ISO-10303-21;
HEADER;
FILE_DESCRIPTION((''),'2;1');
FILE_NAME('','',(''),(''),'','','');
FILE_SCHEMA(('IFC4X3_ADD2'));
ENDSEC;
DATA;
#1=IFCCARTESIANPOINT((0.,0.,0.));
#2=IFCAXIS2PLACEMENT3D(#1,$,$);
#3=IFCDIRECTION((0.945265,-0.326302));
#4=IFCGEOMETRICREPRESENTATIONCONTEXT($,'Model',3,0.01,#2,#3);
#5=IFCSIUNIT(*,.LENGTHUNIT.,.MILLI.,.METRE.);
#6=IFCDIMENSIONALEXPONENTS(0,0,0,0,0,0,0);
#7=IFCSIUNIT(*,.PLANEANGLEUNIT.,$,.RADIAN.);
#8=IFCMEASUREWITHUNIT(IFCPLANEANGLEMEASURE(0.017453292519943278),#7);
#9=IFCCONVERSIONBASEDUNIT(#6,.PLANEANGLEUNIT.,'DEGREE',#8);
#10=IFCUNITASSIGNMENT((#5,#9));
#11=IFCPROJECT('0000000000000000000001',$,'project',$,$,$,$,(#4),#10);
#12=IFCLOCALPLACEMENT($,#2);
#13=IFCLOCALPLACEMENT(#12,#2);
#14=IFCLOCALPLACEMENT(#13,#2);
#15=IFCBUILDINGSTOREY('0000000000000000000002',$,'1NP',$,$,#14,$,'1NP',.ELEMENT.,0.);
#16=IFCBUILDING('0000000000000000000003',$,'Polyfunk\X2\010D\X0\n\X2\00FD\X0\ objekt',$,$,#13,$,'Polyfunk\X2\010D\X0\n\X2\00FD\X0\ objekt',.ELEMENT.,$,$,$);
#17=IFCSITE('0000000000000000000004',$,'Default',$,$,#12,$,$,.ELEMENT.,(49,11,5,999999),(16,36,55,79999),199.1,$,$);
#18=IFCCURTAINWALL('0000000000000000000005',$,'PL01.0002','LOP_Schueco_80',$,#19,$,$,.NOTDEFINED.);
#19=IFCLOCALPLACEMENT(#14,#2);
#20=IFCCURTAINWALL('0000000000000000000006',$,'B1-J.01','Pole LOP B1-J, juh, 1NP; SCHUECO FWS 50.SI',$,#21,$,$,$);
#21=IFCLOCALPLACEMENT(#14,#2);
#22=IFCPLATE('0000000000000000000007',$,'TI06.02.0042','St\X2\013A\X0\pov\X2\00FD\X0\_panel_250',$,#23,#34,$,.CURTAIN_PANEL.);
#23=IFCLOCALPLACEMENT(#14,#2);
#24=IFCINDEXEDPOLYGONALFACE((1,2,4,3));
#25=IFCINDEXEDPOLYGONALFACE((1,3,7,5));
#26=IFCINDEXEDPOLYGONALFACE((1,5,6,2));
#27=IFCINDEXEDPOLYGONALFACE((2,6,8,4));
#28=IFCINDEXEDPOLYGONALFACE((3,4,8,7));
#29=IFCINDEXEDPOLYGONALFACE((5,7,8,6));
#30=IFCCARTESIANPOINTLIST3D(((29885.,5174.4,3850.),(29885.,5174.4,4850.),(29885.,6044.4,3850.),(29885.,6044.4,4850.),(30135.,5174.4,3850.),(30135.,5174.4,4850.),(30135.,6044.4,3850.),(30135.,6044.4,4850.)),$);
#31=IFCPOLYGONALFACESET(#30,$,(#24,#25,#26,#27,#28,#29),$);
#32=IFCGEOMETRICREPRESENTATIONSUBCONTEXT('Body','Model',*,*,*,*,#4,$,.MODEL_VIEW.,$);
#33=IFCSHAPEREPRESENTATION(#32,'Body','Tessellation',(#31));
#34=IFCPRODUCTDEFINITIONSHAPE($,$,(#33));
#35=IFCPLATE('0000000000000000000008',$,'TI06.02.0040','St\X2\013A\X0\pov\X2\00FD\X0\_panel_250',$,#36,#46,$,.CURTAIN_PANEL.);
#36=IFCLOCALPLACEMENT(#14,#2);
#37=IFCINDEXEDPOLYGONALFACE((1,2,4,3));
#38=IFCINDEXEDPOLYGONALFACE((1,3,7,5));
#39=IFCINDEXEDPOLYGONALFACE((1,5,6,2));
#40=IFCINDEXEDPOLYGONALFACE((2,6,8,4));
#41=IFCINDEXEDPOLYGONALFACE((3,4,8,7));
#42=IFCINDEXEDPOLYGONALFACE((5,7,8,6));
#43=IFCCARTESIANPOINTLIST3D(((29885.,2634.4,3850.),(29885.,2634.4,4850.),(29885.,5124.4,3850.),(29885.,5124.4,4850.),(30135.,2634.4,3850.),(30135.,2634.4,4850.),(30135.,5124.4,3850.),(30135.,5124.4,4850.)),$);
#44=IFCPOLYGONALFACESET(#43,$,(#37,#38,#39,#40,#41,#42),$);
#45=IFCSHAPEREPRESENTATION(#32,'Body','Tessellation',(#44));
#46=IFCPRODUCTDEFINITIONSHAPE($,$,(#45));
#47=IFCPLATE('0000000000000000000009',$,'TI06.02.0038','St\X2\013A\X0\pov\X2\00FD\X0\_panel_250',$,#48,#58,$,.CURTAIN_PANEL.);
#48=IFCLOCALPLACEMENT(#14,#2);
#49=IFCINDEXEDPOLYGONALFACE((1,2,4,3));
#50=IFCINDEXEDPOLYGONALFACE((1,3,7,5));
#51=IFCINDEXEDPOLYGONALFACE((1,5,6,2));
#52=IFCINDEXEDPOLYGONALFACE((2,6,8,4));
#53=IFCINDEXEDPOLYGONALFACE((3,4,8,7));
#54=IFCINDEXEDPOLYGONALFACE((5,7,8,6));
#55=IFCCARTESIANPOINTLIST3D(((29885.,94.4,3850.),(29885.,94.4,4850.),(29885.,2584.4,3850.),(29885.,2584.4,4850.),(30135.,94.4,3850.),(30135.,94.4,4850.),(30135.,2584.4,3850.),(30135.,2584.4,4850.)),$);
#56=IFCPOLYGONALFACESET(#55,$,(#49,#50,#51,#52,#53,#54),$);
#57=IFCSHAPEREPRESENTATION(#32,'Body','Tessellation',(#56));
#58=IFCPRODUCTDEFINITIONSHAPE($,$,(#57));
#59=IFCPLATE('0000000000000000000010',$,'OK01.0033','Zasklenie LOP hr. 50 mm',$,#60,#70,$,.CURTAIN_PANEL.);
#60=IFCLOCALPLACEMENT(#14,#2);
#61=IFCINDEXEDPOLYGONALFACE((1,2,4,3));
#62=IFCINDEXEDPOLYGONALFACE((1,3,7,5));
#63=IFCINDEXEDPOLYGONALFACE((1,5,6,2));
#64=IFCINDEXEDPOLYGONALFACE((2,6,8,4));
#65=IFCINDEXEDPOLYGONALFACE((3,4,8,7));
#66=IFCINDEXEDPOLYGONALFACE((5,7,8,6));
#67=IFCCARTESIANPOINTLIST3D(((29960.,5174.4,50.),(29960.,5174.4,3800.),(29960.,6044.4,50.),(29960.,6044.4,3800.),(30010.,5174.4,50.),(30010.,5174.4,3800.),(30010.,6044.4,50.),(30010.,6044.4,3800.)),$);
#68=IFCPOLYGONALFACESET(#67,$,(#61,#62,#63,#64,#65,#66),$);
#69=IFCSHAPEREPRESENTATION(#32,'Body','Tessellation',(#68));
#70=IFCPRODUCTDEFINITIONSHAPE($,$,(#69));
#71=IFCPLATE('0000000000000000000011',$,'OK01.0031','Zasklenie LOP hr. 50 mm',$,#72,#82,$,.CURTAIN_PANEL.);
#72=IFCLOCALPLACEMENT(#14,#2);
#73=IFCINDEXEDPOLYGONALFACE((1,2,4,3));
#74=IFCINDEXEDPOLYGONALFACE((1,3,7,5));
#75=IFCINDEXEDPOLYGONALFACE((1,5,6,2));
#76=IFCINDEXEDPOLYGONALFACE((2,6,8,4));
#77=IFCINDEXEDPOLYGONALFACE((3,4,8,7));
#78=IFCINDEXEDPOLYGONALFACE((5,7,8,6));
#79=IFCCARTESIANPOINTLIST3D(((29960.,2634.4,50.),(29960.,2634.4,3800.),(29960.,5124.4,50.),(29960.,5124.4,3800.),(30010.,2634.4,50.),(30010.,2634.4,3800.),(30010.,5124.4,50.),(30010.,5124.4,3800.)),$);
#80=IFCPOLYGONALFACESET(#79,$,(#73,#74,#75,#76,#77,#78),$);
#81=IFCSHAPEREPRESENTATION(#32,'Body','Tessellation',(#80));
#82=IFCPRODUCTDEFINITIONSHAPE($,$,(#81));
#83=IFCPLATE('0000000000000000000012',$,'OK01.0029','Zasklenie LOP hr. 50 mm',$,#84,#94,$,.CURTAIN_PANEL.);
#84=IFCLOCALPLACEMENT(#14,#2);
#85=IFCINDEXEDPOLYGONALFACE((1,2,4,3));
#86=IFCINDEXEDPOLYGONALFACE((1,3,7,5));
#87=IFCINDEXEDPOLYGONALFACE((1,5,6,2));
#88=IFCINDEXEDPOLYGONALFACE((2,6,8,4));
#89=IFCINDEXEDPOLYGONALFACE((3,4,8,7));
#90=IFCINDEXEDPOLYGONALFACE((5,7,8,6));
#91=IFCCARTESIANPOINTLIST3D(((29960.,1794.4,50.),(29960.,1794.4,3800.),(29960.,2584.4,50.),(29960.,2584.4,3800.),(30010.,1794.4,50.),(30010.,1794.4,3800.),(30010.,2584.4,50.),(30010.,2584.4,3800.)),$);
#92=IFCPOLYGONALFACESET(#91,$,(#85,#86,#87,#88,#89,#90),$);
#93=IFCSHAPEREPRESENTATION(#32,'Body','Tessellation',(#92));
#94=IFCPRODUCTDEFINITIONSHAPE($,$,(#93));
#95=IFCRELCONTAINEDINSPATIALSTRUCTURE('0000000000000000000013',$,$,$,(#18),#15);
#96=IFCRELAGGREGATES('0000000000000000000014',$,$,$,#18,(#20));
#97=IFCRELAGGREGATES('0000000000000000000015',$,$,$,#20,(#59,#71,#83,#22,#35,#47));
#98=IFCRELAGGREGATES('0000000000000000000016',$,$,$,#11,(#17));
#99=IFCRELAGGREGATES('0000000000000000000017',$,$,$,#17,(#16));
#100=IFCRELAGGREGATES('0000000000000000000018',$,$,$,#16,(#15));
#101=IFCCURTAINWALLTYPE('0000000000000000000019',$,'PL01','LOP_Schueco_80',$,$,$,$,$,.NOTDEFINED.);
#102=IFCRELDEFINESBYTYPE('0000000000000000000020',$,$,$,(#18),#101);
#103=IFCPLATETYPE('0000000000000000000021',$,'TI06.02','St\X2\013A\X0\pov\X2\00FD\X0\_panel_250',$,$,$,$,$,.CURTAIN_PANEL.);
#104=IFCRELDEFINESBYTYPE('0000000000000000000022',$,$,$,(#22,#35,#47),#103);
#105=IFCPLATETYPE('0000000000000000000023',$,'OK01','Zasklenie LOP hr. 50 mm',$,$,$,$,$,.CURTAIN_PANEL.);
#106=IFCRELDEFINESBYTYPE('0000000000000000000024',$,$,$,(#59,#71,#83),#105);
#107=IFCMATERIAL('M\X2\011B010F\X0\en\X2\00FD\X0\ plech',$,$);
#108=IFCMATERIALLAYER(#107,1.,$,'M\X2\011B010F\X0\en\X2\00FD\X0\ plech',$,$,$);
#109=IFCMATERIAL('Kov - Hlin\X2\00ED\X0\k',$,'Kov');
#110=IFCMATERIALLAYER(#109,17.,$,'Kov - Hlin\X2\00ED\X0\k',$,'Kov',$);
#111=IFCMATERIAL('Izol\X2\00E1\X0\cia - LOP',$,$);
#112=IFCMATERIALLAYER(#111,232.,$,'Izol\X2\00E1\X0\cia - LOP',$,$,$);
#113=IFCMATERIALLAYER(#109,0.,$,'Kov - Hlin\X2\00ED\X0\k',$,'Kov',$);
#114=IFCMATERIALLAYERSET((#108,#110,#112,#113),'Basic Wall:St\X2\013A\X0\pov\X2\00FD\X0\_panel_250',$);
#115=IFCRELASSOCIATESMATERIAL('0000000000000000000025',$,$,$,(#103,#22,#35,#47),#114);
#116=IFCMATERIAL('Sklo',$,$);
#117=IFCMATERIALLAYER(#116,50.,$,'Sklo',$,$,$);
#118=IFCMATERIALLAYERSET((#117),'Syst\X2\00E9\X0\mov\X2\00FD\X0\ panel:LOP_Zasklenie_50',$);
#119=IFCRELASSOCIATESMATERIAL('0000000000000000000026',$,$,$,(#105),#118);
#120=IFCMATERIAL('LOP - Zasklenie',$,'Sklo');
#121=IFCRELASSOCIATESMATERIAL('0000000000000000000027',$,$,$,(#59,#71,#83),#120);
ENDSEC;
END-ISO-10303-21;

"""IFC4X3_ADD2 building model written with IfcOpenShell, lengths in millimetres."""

from ifc_helpers import new_model, entity, si_unit, converted_unit, direction, frame, frame_2d, origin, place, context, subcontext, project, spatial, rectangle, extrude, source, transform, mapped, material, layer, layer_set, layer_usage, type_object, type_shapes, element, aggregate, save


model = new_model("IFC4X3_ADD2")

# Units and contexts
model_context = context("Model", 3, precision=0.01, world=origin(), true_north=direction((0.945265, -0.326302)))
body_context = subcontext(model_context, "Body", "Model", "MODEL_VIEW")
ifc_project = project(units=[si_unit("LENGTHUNIT", "METRE", prefix="MILLI"), converted_unit("PLANEANGLEUNIT", "DEGREE", entity("IfcPlaneAngleMeasure", 0.017453292519943278), si_unit("PLANEANGLEUNIT", "RADIAN"), dimensions=[0, 0, 0, 0, 0, 0, 0])], contexts=[model_context])

# Site, building, storey
site_placement = place(None, origin())
site = spatial("IfcSite", under=ifc_project, at=site_placement, Name="Default", CompositionType="ELEMENT", RefLatitude=(49, 11, 5, 999999), RefLongitude=(16, 36, 55, 79999), RefElevation=199.1)
building_placement = place(site_placement, origin())
building = spatial("IfcBuilding", under=site, at=building_placement, Name="Polyfunkčný objekt", LongName="Polyfunkčný objekt", CompositionType="ELEMENT")
storey_placement = place(building_placement, origin())
storey = spatial("IfcBuildingStorey", under=building, at=storey_placement, Name="1NP", LongName="1NP", CompositionType="ELEMENT", Elevation=0.0)

# Curtain walls, plates
curtain_wall_type = type_object("IfcCurtainWallType", Name="PL01", Description="LOP_Schueco_80", PredefinedType="NOTDEFINED")
curtain_wall_1_placement = place(storey_placement, origin())
curtain_wall_1 = element("IfcCurtainWall", 1, at=curtain_wall_1_placement, inside=storey, type_object=curtain_wall_type, Name="PL01.0002", Description="LOP_Schueco_80", PredefinedType="NOTDEFINED")
curtain_wall_2 = element("IfcCurtainWall", 2, Name="B1-J.01", Description="Pole LOP B1-J, juh, 1NP; SCHUECO FWS 50.SI")
aggregate(curtain_wall_1, [curtain_wall_2])
ifc_material_1 = material(Name="Měďený plech")
ifc_layer_1 = layer(ifc_material_1, 1.0, Name="Měďený plech")
ifc_material_2 = material(Name="Kov - Hliník", Category="Kov")
ifc_layer_2 = layer(ifc_material_2, 17.0, Name="Kov - Hliník", Category="Kov")
ifc_material_3 = material(Name="Izolácia - LOP")
ifc_layer_3 = layer(ifc_material_3, 232.0, Name="Izolácia - LOP")
ifc_layer_4 = layer(ifc_material_2, 0.0, Name="Kov - Hliník", Category="Kov")
ifc_layer_set_1 = layer_set([ifc_layer_1, ifc_layer_2, ifc_layer_3, ifc_layer_4], Name="Basic Wall:Stĺpový_panel_250")
ifc_layer_usage_1 = layer_usage(ifc_layer_set_1, "AXIS2", "POSITIVE", -125.0)
plate_type_1 = type_object("IfcPlateType", Name="TI06.02", Description="Stĺpový_panel_250", PredefinedType="CURTAIN_PANEL", material=ifc_layer_set_1)
plate_1_placement = place(storey_placement, frame((30010.0, 6044.4, 3850.0), z_axis=(0.0, 0.0, 1.0), x_axis=(0.0, -1.0, 0.0)))
plate_1 = element("IfcPlate", 3, at=plate_1_placement, type_object=plate_type_1, material=ifc_layer_usage_1, Name="TI06.02.0042", Description="Stĺpový_panel_250", PredefinedType="CURTAIN_PANEL", context=body_context, shape_type="SweptSolid", body=[
    extrude(rectangle(XDim=250.0, YDim=870.0, at=frame_2d((0.0, 0.0), x_axis=(1.0, 0.0))), frame((435.0, 0.0, 0.0), z_axis=(0.0, 0.0, 1.0), x_axis=(0.0, 1.0, 0.0)), (0.0, 0.0, 1.0), 1000.0),
])
ifc_layer_usage_2 = layer_usage(ifc_layer_set_1, "AXIS2", "POSITIVE", -125.0)
plate_2_placement = place(storey_placement, frame((30010.0, 5124.4, 3850.0), z_axis=(0.0, 0.0, 1.0), x_axis=(0.0, -1.0, 0.0)))
plate_2 = element("IfcPlate", 4, at=plate_2_placement, type_object=plate_type_1, material=ifc_layer_usage_2, Name="TI06.02.0040", Description="Stĺpový_panel_250", PredefinedType="CURTAIN_PANEL", context=body_context, shape_type="SweptSolid", body=[
    extrude(rectangle(XDim=250.0, YDim=2490.0, at=frame_2d((0.0, 0.0), x_axis=(1.0, 0.0))), frame((1245.0, 0.0, 0.0), z_axis=(0.0, 0.0, 1.0), x_axis=(0.0, 1.0, 0.0)), (0.0, 0.0, 1.0), 1000.0),
])
ifc_layer_usage_3 = layer_usage(ifc_layer_set_1, "AXIS2", "POSITIVE", -125.0)
plate_3_placement = place(storey_placement, frame((30010.0, 2584.4, 3850.0), z_axis=(0.0, 0.0, 1.0), x_axis=(0.0, -1.0, 0.0)))
plate_3 = element("IfcPlate", 5, at=plate_3_placement, type_object=plate_type_1, material=ifc_layer_usage_3, Name="TI06.02.0038", Description="Stĺpový_panel_250", PredefinedType="CURTAIN_PANEL", context=body_context, shape_type="SweptSolid", body=[
    extrude(rectangle(XDim=250.0, YDim=2490.0, at=frame_2d((0.0, 0.0), x_axis=(1.0, 0.0))), frame((1245.0, 0.0, 0.0), z_axis=(0.0, 0.0, 1.0), x_axis=(0.0, 1.0, 0.0)), (0.0, 0.0, 1.0), 1000.0),
])
ifc_material_4 = material(Name="LOP - Zasklenie", Category="Sklo")
ifc_material_5 = material(Name="Sklo")
ifc_layer_5 = layer(ifc_material_5, 50.0, Name="Sklo")
ifc_layer_set_2 = layer_set([ifc_layer_5], Name="Systémový panel:LOP_Zasklenie_50")
plate_type_2 = type_object("IfcPlateType", Name="OK01", Description="Zasklenie LOP hr. 50 mm", PredefinedType="CURTAIN_PANEL", material=ifc_layer_set_2)
shared_shape_1 = source(origin(), body_context, "Body", "SweptSolid", [
    extrude(rectangle(XDim=3750.0, YDim=870.0, at=frame_2d((-141.7, 0.0), x_axis=(1.0, 0.0))), frame((0.0, -50.0, 2016.7), z_axis=(0.0, 1.0, 0.0), x_axis=(0.0, 0.0, 1.0)), (0.0, 0.0, 1.0), 50.0),
])
plate_4_placement = place(curtain_wall_1_placement, frame((30010.0, 5609.4, 50.0), z_axis=(0.0, 0.0, 1.0), x_axis=(0.0, -1.0, 0.0)))
plate_4 = element("IfcPlate", 6, at=plate_4_placement, type_object=plate_type_2, material=ifc_material_4, Name="OK01.0033", Description="Zasklenie LOP hr. 50 mm", PredefinedType="CURTAIN_PANEL", context=body_context, shape_type="MappedRepresentation", body=[
    mapped(shared_shape_1, transform((0.0, 0.0, 0.0), scale=1.0)),
])
shared_shape_2 = source(origin(), body_context, "Body", "SweptSolid", [
    extrude(rectangle(XDim=3750.0, YDim=2490.0, at=frame_2d((-141.7, 0.0), x_axis=(1.0, 0.0))), frame((0.0, -50.0, 2016.7), z_axis=(0.0, 1.0, 0.0), x_axis=(0.0, 0.0, 1.0)), (0.0, 0.0, 1.0), 50.0),
])
plate_5_placement = place(curtain_wall_1_placement, frame((30010.0, 3879.4, 50.0), z_axis=(0.0, 0.0, 1.0), x_axis=(0.0, -1.0, 0.0)))
plate_5 = element("IfcPlate", 7, at=plate_5_placement, type_object=plate_type_2, material=ifc_material_4, Name="OK01.0031", Description="Zasklenie LOP hr. 50 mm", PredefinedType="CURTAIN_PANEL", context=body_context, shape_type="MappedRepresentation", body=[
    mapped(shared_shape_2, transform((0.0, 0.0, 0.0), scale=1.0)),
])
shared_shape_3 = source(origin(), body_context, "Body", "SweptSolid", [
    extrude(rectangle(XDim=3750.0, YDim=790.0, at=frame_2d((-141.7, 0.0), x_axis=(1.0, 0.0))), frame((0.0, -50.0, 2016.7), z_axis=(0.0, 1.0, 0.0), x_axis=(0.0, 0.0, 1.0)), (0.0, 0.0, 1.0), 50.0),
])
type_shapes(plate_type_2, [shared_shape_1, shared_shape_2, shared_shape_3])
plate_6_placement = place(curtain_wall_1_placement, frame((30010.0, 2189.4, 50.0), z_axis=(0.0, 0.0, 1.0), x_axis=(0.0, -1.0, 0.0)))
plate_6 = element("IfcPlate", 8, at=plate_6_placement, type_object=plate_type_2, material=ifc_material_4, Name="OK01.0029", Description="Zasklenie LOP hr. 50 mm", PredefinedType="CURTAIN_PANEL", context=body_context, shape_type="MappedRepresentation", body=[
    mapped(shared_shape_3, transform((0.0, 0.0, 0.0), scale=1.0)),
])
aggregate(curtain_wall_2, [plate_4, plate_5, plate_6, plate_1, plate_2, plate_3])

save(model, "model.ifc")
